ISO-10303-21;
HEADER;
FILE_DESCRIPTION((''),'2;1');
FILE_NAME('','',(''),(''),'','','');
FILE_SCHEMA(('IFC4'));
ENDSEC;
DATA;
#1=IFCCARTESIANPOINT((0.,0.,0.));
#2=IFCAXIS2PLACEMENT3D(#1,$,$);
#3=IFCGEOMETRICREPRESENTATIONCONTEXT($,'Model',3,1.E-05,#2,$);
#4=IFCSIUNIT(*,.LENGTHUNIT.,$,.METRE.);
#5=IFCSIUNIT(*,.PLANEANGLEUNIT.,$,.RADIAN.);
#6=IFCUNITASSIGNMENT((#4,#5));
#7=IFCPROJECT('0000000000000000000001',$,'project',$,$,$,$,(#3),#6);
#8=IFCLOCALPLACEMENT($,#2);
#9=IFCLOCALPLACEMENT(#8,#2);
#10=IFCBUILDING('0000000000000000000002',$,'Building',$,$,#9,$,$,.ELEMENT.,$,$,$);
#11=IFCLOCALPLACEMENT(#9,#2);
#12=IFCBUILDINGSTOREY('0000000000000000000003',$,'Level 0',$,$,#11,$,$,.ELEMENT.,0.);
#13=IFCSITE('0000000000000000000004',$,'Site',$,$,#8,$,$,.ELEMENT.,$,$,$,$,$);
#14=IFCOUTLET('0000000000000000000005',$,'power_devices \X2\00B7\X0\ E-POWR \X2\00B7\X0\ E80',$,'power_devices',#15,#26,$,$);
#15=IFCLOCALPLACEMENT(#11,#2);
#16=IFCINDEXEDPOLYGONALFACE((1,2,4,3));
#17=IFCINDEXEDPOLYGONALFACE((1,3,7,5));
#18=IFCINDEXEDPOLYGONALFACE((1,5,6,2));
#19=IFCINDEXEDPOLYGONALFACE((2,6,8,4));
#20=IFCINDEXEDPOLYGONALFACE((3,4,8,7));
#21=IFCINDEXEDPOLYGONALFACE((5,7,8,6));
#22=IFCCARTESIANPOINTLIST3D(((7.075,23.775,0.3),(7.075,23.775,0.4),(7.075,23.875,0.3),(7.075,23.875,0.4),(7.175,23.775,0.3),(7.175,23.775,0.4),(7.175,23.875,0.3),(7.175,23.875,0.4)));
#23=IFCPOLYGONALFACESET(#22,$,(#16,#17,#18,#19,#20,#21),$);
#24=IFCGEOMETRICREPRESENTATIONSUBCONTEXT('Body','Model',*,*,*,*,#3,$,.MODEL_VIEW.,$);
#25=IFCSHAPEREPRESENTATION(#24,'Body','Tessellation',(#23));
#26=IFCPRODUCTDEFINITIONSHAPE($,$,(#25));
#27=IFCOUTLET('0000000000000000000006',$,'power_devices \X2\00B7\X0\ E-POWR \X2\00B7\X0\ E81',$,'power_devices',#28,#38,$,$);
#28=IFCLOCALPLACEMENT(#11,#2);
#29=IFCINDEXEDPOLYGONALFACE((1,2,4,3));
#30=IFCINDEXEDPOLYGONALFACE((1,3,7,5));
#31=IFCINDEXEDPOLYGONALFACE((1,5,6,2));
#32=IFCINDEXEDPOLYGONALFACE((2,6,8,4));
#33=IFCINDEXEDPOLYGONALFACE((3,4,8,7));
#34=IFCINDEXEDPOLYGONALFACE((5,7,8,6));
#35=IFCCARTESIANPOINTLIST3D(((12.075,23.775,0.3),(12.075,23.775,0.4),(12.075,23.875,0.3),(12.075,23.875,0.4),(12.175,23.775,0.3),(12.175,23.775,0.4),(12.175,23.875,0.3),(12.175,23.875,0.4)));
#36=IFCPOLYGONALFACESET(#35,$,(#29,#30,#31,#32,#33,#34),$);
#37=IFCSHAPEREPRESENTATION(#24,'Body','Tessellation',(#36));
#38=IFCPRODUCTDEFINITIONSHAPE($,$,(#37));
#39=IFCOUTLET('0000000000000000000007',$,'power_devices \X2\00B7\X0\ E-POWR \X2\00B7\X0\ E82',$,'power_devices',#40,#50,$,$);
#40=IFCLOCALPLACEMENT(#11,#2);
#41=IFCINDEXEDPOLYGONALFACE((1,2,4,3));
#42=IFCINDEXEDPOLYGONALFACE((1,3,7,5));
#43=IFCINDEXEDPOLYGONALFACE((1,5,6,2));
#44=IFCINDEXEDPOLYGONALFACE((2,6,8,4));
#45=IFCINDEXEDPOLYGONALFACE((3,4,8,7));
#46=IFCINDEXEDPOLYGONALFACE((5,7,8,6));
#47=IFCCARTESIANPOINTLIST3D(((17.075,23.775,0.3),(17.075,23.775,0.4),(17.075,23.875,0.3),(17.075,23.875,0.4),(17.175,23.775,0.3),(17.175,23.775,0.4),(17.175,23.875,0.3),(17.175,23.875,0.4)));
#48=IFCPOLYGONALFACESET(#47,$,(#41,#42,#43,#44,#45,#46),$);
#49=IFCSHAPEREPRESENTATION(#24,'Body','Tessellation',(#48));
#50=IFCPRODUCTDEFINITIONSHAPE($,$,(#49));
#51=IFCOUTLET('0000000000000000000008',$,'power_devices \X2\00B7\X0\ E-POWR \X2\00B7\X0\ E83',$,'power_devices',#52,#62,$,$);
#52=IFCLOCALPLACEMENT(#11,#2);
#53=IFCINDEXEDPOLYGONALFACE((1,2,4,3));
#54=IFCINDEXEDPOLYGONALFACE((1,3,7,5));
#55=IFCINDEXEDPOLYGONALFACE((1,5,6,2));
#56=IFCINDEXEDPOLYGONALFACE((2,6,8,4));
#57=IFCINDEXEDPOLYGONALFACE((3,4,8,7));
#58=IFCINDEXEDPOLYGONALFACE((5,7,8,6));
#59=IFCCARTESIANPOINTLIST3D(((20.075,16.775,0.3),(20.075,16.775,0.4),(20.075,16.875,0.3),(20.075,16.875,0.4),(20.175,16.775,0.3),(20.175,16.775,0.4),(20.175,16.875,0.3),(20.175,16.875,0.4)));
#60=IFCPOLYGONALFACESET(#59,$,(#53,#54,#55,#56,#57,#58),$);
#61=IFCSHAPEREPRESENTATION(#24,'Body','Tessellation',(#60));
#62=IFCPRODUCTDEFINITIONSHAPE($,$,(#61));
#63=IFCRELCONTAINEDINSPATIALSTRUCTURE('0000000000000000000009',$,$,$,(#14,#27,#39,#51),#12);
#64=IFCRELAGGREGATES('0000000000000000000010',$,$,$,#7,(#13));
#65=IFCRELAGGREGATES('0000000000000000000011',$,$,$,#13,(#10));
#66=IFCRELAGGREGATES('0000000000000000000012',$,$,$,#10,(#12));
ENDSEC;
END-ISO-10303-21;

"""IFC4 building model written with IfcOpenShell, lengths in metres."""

from ifc_helpers import new_model, si_unit, frame, origin, place, context, subcontext, project, spatial, polyline, outline, extrude, element, save


model = new_model("IFC4")

# Units and contexts
model_context = context("Model", 3, precision=1e-05, world=origin())
body_context = subcontext(model_context, "Body", "Model", "MODEL_VIEW")
ifc_project = project(units=[si_unit("LENGTHUNIT", "METRE"), si_unit("PLANEANGLEUNIT", "RADIAN")], contexts=[model_context])

# Site, building, storey
site_placement = place(None, origin())
site = spatial("IfcSite", under=ifc_project, at=site_placement, Name="Site", CompositionType="ELEMENT")
building_placement = place(site_placement, origin())
building = spatial("IfcBuilding", under=site, at=building_placement, Name="Building", CompositionType="ELEMENT")
storey_placement = place(building_placement, origin())
storey = spatial("IfcBuildingStorey", under=building, at=storey_placement, Name="Level 0", CompositionType="ELEMENT", Elevation=0.0)

# Outlets
outlet_1_placement = place(storey_placement, frame((0.0, 0.0, 0.3)))
element("IfcOutlet", 1, at=outlet_1_placement, inside=storey, Name="power_devices · E-POWR · E80", ObjectType="power_devices", context=body_context, shape_type="SweptSolid", body=[
    extrude(outline(polyline([(7.075, 23.775), (7.175, 23.775), (7.175, 23.875), (7.075, 23.875), (7.075, 23.775)])), origin(), (0.0, 0.0, 1.0), 0.1),
])
outlet_2_placement = place(storey_placement, frame((0.0, 0.0, 0.3)))
element("IfcOutlet", 2, at=outlet_2_placement, inside=storey, Name="power_devices · E-POWR · E81", ObjectType="power_devices", context=body_context, shape_type="SweptSolid", body=[
    extrude(outline(polyline([(12.075, 23.775), (12.175, 23.775), (12.175, 23.875), (12.075, 23.875), (12.075, 23.775)])), origin(), (0.0, 0.0, 1.0), 0.1),
])
outlet_3_placement = place(storey_placement, frame((0.0, 0.0, 0.3)))
element("IfcOutlet", 3, at=outlet_3_placement, inside=storey, Name="power_devices · E-POWR · E82", ObjectType="power_devices", context=body_context, shape_type="SweptSolid", body=[
    extrude(outline(polyline([(17.075, 23.775), (17.175, 23.775), (17.175, 23.875), (17.075, 23.875), (17.075, 23.775)])), origin(), (0.0, 0.0, 1.0), 0.1),
])
outlet_4_placement = place(storey_placement, frame((0.0, 0.0, 0.3)))
element("IfcOutlet", 4, at=outlet_4_placement, inside=storey, Name="power_devices · E-POWR · E83", ObjectType="power_devices", context=body_context, shape_type="SweptSolid", body=[
    extrude(outline(polyline([(20.075, 16.775), (20.175, 16.775), (20.175, 16.875), (20.075, 16.875), (20.075, 16.775)])), origin(), (0.0, 0.0, 1.0), 0.1),
])

save(model, "model.ifc")
